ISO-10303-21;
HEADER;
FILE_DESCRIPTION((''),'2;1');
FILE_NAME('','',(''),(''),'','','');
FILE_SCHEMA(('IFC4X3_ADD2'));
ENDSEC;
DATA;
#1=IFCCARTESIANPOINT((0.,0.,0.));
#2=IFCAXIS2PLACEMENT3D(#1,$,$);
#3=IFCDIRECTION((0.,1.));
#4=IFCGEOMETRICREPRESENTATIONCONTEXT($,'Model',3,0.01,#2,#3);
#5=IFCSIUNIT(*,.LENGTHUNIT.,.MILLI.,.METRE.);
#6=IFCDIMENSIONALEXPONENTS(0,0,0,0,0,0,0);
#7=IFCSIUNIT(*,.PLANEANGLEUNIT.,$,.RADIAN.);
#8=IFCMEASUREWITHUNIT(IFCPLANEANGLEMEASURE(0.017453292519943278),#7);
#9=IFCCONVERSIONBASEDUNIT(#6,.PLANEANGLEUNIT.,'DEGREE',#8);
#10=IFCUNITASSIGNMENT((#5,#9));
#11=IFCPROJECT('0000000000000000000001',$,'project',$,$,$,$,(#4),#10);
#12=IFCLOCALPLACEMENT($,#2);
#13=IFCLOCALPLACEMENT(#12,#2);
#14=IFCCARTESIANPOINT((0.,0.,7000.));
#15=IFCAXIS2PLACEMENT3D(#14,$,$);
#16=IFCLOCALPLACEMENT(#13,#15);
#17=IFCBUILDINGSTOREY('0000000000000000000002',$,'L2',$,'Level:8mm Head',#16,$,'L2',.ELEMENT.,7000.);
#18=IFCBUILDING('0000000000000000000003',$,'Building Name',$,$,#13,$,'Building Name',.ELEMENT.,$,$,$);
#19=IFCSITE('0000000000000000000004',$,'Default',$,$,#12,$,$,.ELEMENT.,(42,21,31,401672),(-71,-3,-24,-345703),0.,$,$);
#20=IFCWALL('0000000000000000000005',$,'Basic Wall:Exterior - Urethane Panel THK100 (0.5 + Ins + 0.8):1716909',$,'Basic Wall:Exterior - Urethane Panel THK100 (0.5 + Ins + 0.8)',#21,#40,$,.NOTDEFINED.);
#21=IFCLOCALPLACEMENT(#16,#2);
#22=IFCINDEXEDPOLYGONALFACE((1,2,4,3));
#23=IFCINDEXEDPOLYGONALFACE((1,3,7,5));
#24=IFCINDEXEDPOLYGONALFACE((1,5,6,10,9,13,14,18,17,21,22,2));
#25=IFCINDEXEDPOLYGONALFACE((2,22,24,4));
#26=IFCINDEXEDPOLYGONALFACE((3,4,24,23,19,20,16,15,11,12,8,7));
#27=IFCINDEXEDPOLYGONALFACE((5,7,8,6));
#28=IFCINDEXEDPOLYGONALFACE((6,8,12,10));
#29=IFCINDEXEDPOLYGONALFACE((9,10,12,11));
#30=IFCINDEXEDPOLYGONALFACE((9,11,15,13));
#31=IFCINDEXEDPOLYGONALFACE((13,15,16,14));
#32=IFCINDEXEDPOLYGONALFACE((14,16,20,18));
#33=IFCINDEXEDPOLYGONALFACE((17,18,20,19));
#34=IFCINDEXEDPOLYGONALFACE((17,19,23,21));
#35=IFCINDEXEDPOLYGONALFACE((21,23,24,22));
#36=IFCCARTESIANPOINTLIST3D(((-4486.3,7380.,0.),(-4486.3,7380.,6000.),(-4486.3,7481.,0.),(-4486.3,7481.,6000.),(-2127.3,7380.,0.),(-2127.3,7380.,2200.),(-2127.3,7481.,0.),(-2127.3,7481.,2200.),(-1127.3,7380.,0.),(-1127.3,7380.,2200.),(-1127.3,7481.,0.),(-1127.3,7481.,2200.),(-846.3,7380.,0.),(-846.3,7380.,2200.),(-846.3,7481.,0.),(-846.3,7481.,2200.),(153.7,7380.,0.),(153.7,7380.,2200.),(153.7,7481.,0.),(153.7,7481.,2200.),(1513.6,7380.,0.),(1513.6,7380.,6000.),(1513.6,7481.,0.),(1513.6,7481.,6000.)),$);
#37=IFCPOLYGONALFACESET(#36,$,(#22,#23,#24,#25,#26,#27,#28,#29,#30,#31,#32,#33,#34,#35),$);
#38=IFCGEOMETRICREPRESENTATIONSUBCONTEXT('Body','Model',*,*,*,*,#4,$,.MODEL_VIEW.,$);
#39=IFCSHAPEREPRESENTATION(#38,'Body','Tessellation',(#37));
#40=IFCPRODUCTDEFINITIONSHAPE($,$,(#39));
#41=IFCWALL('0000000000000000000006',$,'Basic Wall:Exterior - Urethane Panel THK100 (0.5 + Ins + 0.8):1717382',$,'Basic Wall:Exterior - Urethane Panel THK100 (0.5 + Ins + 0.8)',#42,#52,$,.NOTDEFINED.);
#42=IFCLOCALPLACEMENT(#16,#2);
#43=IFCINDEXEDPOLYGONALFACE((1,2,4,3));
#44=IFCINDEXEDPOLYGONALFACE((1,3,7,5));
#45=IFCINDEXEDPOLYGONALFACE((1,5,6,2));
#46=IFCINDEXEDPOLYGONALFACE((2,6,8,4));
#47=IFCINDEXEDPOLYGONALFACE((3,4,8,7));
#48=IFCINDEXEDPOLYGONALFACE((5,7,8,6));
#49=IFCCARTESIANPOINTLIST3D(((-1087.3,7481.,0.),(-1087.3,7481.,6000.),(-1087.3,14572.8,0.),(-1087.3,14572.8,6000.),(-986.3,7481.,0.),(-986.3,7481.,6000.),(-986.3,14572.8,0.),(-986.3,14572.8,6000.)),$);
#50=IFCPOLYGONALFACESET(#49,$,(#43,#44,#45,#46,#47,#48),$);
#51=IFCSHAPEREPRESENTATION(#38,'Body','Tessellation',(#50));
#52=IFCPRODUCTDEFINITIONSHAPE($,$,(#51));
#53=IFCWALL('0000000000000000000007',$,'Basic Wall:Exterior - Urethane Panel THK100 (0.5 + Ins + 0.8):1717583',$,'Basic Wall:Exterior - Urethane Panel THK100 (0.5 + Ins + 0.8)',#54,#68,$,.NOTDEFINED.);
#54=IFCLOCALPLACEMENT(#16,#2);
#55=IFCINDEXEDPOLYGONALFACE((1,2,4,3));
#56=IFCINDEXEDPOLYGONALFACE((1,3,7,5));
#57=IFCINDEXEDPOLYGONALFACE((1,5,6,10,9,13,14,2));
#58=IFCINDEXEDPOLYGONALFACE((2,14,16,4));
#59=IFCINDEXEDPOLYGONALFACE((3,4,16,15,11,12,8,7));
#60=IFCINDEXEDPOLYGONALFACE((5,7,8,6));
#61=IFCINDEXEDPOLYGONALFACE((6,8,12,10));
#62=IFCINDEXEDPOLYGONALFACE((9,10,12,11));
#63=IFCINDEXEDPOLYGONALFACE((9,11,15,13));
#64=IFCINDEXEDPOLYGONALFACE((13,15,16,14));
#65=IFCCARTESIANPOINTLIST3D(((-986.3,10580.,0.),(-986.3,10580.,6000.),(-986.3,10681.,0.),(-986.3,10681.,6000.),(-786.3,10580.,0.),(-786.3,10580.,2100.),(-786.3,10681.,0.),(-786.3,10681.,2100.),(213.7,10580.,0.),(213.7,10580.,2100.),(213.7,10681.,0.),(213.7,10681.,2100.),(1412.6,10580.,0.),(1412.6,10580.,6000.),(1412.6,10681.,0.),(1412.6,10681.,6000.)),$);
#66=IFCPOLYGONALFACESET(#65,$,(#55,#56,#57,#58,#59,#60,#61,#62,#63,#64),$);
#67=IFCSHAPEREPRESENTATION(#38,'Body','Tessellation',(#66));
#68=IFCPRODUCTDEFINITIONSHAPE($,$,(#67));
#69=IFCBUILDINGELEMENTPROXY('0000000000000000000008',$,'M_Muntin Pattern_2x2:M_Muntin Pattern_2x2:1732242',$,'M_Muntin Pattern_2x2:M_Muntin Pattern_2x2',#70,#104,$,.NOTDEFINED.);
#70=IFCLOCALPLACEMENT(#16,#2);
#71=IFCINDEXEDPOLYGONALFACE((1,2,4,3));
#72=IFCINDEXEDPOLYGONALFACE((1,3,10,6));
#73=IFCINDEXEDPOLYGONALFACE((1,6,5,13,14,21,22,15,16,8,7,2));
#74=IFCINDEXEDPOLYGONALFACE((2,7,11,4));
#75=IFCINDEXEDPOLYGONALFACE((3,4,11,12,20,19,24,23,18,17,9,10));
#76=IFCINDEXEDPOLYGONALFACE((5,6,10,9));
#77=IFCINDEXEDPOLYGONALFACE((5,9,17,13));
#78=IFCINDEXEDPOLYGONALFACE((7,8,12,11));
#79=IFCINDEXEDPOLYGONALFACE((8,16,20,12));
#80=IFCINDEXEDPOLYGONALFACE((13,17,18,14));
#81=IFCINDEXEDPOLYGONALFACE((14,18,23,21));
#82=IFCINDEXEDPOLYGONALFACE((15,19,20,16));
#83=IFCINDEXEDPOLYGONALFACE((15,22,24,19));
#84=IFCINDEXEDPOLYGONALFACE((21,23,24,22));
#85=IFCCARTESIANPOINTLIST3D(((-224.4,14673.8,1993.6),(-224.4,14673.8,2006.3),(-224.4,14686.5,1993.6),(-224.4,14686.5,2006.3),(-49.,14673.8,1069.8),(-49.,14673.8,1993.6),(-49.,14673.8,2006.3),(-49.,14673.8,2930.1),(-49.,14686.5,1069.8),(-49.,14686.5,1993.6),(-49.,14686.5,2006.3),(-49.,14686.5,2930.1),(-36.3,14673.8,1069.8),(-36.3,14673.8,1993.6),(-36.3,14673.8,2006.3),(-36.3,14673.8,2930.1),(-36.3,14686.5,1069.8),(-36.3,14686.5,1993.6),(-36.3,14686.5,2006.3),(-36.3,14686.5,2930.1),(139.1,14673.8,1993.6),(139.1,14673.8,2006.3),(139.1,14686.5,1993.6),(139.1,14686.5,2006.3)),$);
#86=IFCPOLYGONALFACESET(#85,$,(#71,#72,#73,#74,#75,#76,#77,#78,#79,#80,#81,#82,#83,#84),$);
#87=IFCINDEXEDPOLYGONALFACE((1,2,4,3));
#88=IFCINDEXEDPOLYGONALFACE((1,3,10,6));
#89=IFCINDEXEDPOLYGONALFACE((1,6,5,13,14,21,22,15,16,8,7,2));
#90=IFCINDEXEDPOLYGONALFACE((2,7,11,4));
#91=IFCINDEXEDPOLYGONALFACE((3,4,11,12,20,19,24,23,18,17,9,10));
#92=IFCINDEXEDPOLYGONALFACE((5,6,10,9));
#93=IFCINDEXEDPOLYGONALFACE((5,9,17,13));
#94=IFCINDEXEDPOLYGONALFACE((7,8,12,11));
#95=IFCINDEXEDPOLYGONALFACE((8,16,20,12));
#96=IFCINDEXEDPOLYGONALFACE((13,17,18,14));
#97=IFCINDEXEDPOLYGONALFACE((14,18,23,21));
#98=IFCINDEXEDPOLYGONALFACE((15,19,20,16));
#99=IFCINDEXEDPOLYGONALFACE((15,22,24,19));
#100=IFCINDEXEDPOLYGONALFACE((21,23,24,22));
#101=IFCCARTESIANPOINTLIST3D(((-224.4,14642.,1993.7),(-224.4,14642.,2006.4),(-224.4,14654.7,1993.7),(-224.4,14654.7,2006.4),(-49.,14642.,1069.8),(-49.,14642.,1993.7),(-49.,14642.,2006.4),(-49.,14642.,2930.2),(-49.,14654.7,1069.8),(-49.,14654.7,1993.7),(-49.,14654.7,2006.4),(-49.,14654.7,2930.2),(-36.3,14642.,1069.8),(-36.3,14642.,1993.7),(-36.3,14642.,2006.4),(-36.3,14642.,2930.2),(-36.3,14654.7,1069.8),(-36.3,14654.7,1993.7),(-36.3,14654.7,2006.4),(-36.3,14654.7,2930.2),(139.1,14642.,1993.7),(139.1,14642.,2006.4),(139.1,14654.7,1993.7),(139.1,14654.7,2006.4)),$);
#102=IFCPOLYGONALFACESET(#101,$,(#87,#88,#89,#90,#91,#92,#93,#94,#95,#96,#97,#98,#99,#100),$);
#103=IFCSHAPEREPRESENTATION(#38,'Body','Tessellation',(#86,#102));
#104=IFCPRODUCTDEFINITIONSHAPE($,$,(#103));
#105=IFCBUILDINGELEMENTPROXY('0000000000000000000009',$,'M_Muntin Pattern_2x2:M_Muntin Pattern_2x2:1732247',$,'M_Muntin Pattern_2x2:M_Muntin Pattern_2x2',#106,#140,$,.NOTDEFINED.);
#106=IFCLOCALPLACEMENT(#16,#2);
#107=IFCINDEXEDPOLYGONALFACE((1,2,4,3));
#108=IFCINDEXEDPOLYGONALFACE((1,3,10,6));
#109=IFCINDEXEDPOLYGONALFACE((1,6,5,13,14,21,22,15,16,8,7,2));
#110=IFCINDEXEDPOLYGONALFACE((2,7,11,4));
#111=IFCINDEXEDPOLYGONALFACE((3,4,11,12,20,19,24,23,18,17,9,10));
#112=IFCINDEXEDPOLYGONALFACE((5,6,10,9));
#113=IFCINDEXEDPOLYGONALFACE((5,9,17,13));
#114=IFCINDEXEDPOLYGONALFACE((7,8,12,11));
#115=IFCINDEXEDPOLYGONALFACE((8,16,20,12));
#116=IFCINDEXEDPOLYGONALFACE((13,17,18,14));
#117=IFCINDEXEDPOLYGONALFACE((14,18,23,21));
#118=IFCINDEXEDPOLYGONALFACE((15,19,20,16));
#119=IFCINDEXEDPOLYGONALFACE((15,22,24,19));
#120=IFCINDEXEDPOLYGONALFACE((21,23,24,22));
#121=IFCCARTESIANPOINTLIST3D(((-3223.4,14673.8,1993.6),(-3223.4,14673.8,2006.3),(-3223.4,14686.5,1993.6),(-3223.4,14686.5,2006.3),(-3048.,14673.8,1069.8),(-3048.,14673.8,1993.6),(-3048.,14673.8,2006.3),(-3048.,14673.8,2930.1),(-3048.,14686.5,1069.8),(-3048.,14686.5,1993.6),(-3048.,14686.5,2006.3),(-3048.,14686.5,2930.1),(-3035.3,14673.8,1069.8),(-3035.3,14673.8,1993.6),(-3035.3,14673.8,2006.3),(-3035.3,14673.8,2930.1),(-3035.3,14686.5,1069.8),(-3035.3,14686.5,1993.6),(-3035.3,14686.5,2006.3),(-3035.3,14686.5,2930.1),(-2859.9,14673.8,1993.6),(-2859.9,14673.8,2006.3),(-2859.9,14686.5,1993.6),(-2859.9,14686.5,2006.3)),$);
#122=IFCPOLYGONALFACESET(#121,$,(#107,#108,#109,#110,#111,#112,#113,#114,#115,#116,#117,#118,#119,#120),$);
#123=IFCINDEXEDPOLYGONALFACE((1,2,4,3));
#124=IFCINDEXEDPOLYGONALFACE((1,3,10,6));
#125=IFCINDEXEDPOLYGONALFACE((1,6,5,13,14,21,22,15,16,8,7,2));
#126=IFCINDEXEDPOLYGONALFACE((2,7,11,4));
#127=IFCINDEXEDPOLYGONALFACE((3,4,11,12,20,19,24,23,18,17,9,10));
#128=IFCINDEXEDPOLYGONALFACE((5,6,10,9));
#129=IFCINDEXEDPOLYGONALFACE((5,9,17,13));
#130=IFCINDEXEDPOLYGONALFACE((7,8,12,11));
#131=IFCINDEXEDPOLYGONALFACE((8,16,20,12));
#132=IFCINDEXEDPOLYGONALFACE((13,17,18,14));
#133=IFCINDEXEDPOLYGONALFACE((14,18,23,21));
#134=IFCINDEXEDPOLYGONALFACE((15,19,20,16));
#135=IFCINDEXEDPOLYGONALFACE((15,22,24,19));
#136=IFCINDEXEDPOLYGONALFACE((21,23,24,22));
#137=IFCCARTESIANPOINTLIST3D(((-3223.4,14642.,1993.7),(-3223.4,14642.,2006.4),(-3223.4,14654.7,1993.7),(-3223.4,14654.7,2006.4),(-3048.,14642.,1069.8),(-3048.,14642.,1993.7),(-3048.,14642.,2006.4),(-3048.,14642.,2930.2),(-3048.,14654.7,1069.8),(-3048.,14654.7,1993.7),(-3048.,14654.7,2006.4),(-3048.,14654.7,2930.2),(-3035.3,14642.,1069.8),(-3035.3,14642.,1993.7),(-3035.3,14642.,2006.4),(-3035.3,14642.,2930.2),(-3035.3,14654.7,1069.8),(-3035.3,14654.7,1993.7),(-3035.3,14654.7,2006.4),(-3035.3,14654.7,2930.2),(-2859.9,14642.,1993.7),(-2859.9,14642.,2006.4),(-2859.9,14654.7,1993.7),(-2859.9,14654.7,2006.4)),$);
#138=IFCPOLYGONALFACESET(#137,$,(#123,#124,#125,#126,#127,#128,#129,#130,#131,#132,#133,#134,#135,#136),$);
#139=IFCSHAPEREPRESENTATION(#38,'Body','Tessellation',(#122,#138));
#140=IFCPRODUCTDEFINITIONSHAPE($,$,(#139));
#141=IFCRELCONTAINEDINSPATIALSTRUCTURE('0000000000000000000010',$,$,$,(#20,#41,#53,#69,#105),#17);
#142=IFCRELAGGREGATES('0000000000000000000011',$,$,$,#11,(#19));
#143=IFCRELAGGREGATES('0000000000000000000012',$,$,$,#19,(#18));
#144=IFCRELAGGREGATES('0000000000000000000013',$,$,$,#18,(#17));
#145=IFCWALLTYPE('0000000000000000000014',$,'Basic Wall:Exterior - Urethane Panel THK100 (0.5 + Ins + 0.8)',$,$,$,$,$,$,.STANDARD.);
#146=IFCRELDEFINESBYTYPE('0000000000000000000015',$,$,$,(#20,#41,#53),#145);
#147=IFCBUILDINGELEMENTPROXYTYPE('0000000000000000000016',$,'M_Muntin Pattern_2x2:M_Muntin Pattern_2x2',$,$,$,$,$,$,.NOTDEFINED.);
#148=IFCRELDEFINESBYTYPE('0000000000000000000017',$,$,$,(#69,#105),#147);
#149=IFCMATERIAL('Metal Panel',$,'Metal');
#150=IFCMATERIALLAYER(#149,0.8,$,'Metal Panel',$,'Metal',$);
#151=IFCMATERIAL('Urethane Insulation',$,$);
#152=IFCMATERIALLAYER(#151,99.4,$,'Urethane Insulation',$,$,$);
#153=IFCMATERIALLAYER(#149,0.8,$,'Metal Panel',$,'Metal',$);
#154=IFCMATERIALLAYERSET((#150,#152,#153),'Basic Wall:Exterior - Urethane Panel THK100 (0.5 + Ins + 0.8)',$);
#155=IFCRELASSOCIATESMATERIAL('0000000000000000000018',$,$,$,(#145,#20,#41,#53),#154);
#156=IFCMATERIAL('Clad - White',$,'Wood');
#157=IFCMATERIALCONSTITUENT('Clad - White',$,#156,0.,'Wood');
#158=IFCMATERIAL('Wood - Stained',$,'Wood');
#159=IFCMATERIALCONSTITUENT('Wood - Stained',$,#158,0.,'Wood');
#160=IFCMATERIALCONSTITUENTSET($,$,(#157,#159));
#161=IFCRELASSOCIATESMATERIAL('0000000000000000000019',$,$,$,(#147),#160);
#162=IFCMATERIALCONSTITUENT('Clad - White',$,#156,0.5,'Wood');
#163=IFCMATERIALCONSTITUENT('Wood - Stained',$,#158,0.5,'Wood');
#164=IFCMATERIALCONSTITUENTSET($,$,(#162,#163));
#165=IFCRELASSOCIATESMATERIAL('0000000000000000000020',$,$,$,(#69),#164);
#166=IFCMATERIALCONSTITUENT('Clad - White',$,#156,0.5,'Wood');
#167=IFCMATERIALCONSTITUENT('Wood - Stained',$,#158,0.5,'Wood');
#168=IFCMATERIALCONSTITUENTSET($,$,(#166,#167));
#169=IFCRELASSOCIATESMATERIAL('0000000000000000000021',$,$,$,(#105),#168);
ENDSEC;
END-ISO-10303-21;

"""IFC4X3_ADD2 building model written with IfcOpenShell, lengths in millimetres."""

from ifc_helpers import new_model, entity, si_unit, converted_unit, direction, frame, frame_2d, origin, place, context, subcontext, project, spatial, polyline, rectangle, outline, extrude, source, transform, mapped, material, layer, layer_set, constituent, constituent_set, type_object, type_shapes, element, save


model = new_model("IFC4X3_ADD2")

# Units and contexts
model_context = context("Model", 3, precision=0.01, world=origin(), true_north=direction((0.0, 1.0)))
body_context = subcontext(model_context, "Body", "Model", "MODEL_VIEW")
ifc_project = project(units=[si_unit("LENGTHUNIT", "METRE", prefix="MILLI"), converted_unit("PLANEANGLEUNIT", "DEGREE", entity("IfcPlaneAngleMeasure", 0.017453292519943278), si_unit("PLANEANGLEUNIT", "RADIAN"), dimensions=[0, 0, 0, 0, 0, 0, 0])], contexts=[model_context])

# Site, building, storey
site_placement = place(None, origin())
site = spatial("IfcSite", under=ifc_project, at=site_placement, Name="Default", CompositionType="ELEMENT", RefLatitude=(42, 21, 31, 401672), RefLongitude=(-71, -3, -24, -345703), RefElevation=0.0)
building_placement = place(site_placement, origin())
building = spatial("IfcBuilding", under=site, at=building_placement, Name="Building Name", LongName="Building Name", CompositionType="ELEMENT")
storey_placement = place(building_placement, frame((0.0, 0.0, 7000.0)))
storey = spatial("IfcBuildingStorey", under=building, at=storey_placement, Name="L2", ObjectType="Level:8mm Head", LongName="L2", CompositionType="ELEMENT", Elevation=7000.0)

# Wall, openings
ifc_material_1 = material(Name="Metal Panel", Category="Metal")
ifc_layer_1 = layer(ifc_material_1, 0.8, Name="Metal Panel", Category="Metal")
ifc_material_2 = material(Name="Urethane Insulation")
ifc_layer_2 = layer(ifc_material_2, 99.4, Name="Urethane Insulation")
ifc_layer_3 = layer(ifc_material_1, 0.8, Name="Metal Panel", Category="Metal")
ifc_layer_set = layer_set([ifc_layer_1, ifc_layer_2, ifc_layer_3], Name="Basic Wall:Exterior - Urethane Panel THK100 (0.5 + Ins + 0.8)")
wall_type = type_object("IfcWallType", Name="Basic Wall:Exterior - Urethane Panel THK100 (0.5 + Ins + 0.8)", PredefinedType="STANDARD", material=ifc_layer_set)
wall_1_placement = place(storey_placement, frame((-4486.3, 7430.5, 0.0)))
wall_1 = element("IfcWall", 1, at=wall_1_placement, inside=storey, type_object=wall_type, material=ifc_layer_set, Name="Basic Wall:Exterior - Urethane Panel THK100 (0.5 + Ins + 0.8):1716909", ObjectType="Basic Wall:Exterior - Urethane Panel THK100 (0.5 + Ins + 0.8)", PredefinedType="NOTDEFINED", context=body_context, shape_type="SweptSolid", body=[
    extrude(rectangle(XDim=5999.9, YDim=101.0, at=frame_2d((3000.0, 0.0), x_axis=(-1.0, 0.0))), origin(), (0.0, 0.0, 1.0), 6000.0),
])
opening_1_placement = place(wall_1_placement, frame((2359.0, -50.5, 0.0)))
element("IfcOpeningElement", 2, at=opening_1_placement, cuts=wall_1, PredefinedType="OPENING", context=body_context, shape_type="SweptSolid", body=[
    extrude(rectangle(XDim=2200.0, YDim=1000.0, at=frame_2d((1100.0, 500.0), x_axis=(1.0, 0.0))), frame((0.0, 0.0, 0.0), z_axis=(0.0, 1.0, 0.0), x_axis=(0.0, 0.0, 1.0)), (0.0, 0.0, 1.0), 101.0),
])
opening_2_placement = place(wall_1_placement, frame((3640.0, -50.5, 0.0)))
element("IfcOpeningElement", 3, at=opening_2_placement, cuts=wall_1, PredefinedType="OPENING", context=body_context, shape_type="SweptSolid", body=[
    extrude(rectangle(XDim=2200.0, YDim=1000.0, at=frame_2d((1100.0, 500.0), x_axis=(1.0, 0.0))), frame((0.0, 0.0, 0.0), z_axis=(0.0, 1.0, 0.0), x_axis=(0.0, 0.0, 1.0)), (0.0, 0.0, 1.0), 101.0),
])

# Wall
wall_2_placement = place(storey_placement, frame((-1036.8, 7481.0, 0.0), z_axis=(0.0, 0.0, 1.0), x_axis=(0.0, 1.0, 0.0)))
element("IfcWall", 4, at=wall_2_placement, inside=storey, type_object=wall_type, material=ifc_layer_set, Name="Basic Wall:Exterior - Urethane Panel THK100 (0.5 + Ins + 0.8):1717382", ObjectType="Basic Wall:Exterior - Urethane Panel THK100 (0.5 + Ins + 0.8)", PredefinedType="NOTDEFINED", context=body_context, shape_type="SweptSolid", body=[
    extrude(rectangle(XDim=7091.8, YDim=101.0, at=frame_2d((3545.9, 0.0), x_axis=(-1.0, 0.0))), origin(), (0.0, 0.0, 1.0), 6000.0),
])

# Wall, opening
wall_3_placement = place(storey_placement, frame((-986.3, 10630.5, 0.0)))
wall_3 = element("IfcWall", 5, at=wall_3_placement, inside=storey, type_object=wall_type, material=ifc_layer_set, Name="Basic Wall:Exterior - Urethane Panel THK100 (0.5 + Ins + 0.8):1717583", ObjectType="Basic Wall:Exterior - Urethane Panel THK100 (0.5 + Ins + 0.8)", PredefinedType="NOTDEFINED", context=body_context, shape_type="SweptSolid", body=[
    extrude(rectangle(XDim=2398.9, YDim=101.0, at=frame_2d((1199.5, 0.0), x_axis=(1.0, 0.0))), origin(), (0.0, 0.0, 1.0), 6000.0),
])
opening_3_placement = place(wall_3_placement, frame((200.0, -50.5, 0.0)))
element("IfcOpeningElement", 6, at=opening_3_placement, cuts=wall_3, PredefinedType="OPENING", context=body_context, shape_type="SweptSolid", body=[
    extrude(rectangle(XDim=2100.0, YDim=1000.0, at=frame_2d((1050.0, 500.0), x_axis=(1.0, 0.0))), frame((0.0, 0.0, 0.0), z_axis=(0.0, 1.0, 0.0), x_axis=(0.0, 0.0, 1.0)), (0.0, 0.0, 1.0), 101.0),
])

# Building element proxies
ifc_material_3 = material(Name="Clad - White", Category="Wood")
ifc_constituent_1 = constituent(ifc_material_3, Name="Clad - White", Category="Wood", fraction=0.5)
ifc_material_4 = material(Name="Wood - Stained", Category="Wood")
ifc_constituent_2 = constituent(ifc_material_4, Name="Wood - Stained", Category="Wood", fraction=0.5)
ifc_constituent_set_1 = constituent_set(constituents=[ifc_constituent_1, ifc_constituent_2])
ifc_constituent_3 = constituent(ifc_material_3, Name="Clad - White", Category="Wood", fraction=0.0)
ifc_constituent_4 = constituent(ifc_material_4, Name="Wood - Stained", Category="Wood", fraction=0.0)
ifc_constituent_set_2 = constituent_set(constituents=[ifc_constituent_3, ifc_constituent_4])
building_element_proxy_type_1 = type_object("IfcBuildingElementProxyType", Name="M_Muntin Pattern_2x2:M_Muntin Pattern_2x2", PredefinedType="NOTDEFINED", material=ifc_constituent_set_2)
shared_shape_1 = source(origin(), body_context, "Body", "SweptSolid", [
    extrude(outline(polyline([(6.4, -6.4), (930.1, -6.4), (930.1, 6.3), (6.4, 6.3), (6.4, 181.7), (-6.3, 181.7), (-6.3, 6.3), (-930.2, 6.3), (-930.2, -6.4), (-6.3, -6.4), (-6.3, -181.7), (6.4, -181.7), (6.4, -6.4)])), frame((0.0, 9.5, 930.1), z_axis=(0.0, 1.0, 0.0), x_axis=(0.0, 0.0, 1.0)), (0.0, 0.0, 1.0), 12.7),
    extrude(outline(polyline([(6.4, -6.4), (930.2, -6.4), (930.2, 6.3), (6.4, 6.3), (6.4, 181.7), (-6.3, 181.7), (-6.3, 6.3), (-930.2, 6.3), (-930.2, -6.4), (-6.3, -6.4), (-6.3, -181.7), (6.4, -181.7), (6.4, -6.4)])), frame((0.0, -22.2, 930.2), z_axis=(0.0, 1.0, 0.0), x_axis=(0.0, 0.0, 1.0)), (0.0, 0.0, 1.0), 12.7),
])
type_shapes(building_element_proxy_type_1, [shared_shape_1])
proxy_1_placement = place(storey_placement, frame((-42.6, 14664.3, 1069.8)))
element("IfcBuildingElementProxy", 7, at=proxy_1_placement, inside=storey, type_object=building_element_proxy_type_1, material=ifc_constituent_set_1, Name="M_Muntin Pattern_2x2:M_Muntin Pattern_2x2:1732242", ObjectType="M_Muntin Pattern_2x2:M_Muntin Pattern_2x2", PredefinedType="NOTDEFINED", context=body_context, shape_type="MappedRepresentation", body=[
    mapped(shared_shape_1, transform((0.0, 0.0, 0.0), scale=1.0)),
])
ifc_constituent_5 = constituent(ifc_material_3, Name="Clad - White", Category="Wood", fraction=0.5)
ifc_constituent_6 = constituent(ifc_material_4, Name="Wood - Stained", Category="Wood", fraction=0.5)
ifc_constituent_set_3 = constituent_set(constituents=[ifc_constituent_5, ifc_constituent_6])
proxy_2_placement = place(storey_placement, frame((-3041.6, 14664.3, 1069.8)))
element("IfcBuildingElementProxy", 8, at=proxy_2_placement, inside=storey, type_object=building_element_proxy_type_1, material=ifc_constituent_set_3, Name="M_Muntin Pattern_2x2:M_Muntin Pattern_2x2:1732247", ObjectType="M_Muntin Pattern_2x2:M_Muntin Pattern_2x2", PredefinedType="NOTDEFINED", context=body_context, shape_type="MappedRepresentation", body=[
    mapped(shared_shape_1, transform((0.0, 0.0, 0.0), scale=1.0)),
])

save(model, "model.ifc")
